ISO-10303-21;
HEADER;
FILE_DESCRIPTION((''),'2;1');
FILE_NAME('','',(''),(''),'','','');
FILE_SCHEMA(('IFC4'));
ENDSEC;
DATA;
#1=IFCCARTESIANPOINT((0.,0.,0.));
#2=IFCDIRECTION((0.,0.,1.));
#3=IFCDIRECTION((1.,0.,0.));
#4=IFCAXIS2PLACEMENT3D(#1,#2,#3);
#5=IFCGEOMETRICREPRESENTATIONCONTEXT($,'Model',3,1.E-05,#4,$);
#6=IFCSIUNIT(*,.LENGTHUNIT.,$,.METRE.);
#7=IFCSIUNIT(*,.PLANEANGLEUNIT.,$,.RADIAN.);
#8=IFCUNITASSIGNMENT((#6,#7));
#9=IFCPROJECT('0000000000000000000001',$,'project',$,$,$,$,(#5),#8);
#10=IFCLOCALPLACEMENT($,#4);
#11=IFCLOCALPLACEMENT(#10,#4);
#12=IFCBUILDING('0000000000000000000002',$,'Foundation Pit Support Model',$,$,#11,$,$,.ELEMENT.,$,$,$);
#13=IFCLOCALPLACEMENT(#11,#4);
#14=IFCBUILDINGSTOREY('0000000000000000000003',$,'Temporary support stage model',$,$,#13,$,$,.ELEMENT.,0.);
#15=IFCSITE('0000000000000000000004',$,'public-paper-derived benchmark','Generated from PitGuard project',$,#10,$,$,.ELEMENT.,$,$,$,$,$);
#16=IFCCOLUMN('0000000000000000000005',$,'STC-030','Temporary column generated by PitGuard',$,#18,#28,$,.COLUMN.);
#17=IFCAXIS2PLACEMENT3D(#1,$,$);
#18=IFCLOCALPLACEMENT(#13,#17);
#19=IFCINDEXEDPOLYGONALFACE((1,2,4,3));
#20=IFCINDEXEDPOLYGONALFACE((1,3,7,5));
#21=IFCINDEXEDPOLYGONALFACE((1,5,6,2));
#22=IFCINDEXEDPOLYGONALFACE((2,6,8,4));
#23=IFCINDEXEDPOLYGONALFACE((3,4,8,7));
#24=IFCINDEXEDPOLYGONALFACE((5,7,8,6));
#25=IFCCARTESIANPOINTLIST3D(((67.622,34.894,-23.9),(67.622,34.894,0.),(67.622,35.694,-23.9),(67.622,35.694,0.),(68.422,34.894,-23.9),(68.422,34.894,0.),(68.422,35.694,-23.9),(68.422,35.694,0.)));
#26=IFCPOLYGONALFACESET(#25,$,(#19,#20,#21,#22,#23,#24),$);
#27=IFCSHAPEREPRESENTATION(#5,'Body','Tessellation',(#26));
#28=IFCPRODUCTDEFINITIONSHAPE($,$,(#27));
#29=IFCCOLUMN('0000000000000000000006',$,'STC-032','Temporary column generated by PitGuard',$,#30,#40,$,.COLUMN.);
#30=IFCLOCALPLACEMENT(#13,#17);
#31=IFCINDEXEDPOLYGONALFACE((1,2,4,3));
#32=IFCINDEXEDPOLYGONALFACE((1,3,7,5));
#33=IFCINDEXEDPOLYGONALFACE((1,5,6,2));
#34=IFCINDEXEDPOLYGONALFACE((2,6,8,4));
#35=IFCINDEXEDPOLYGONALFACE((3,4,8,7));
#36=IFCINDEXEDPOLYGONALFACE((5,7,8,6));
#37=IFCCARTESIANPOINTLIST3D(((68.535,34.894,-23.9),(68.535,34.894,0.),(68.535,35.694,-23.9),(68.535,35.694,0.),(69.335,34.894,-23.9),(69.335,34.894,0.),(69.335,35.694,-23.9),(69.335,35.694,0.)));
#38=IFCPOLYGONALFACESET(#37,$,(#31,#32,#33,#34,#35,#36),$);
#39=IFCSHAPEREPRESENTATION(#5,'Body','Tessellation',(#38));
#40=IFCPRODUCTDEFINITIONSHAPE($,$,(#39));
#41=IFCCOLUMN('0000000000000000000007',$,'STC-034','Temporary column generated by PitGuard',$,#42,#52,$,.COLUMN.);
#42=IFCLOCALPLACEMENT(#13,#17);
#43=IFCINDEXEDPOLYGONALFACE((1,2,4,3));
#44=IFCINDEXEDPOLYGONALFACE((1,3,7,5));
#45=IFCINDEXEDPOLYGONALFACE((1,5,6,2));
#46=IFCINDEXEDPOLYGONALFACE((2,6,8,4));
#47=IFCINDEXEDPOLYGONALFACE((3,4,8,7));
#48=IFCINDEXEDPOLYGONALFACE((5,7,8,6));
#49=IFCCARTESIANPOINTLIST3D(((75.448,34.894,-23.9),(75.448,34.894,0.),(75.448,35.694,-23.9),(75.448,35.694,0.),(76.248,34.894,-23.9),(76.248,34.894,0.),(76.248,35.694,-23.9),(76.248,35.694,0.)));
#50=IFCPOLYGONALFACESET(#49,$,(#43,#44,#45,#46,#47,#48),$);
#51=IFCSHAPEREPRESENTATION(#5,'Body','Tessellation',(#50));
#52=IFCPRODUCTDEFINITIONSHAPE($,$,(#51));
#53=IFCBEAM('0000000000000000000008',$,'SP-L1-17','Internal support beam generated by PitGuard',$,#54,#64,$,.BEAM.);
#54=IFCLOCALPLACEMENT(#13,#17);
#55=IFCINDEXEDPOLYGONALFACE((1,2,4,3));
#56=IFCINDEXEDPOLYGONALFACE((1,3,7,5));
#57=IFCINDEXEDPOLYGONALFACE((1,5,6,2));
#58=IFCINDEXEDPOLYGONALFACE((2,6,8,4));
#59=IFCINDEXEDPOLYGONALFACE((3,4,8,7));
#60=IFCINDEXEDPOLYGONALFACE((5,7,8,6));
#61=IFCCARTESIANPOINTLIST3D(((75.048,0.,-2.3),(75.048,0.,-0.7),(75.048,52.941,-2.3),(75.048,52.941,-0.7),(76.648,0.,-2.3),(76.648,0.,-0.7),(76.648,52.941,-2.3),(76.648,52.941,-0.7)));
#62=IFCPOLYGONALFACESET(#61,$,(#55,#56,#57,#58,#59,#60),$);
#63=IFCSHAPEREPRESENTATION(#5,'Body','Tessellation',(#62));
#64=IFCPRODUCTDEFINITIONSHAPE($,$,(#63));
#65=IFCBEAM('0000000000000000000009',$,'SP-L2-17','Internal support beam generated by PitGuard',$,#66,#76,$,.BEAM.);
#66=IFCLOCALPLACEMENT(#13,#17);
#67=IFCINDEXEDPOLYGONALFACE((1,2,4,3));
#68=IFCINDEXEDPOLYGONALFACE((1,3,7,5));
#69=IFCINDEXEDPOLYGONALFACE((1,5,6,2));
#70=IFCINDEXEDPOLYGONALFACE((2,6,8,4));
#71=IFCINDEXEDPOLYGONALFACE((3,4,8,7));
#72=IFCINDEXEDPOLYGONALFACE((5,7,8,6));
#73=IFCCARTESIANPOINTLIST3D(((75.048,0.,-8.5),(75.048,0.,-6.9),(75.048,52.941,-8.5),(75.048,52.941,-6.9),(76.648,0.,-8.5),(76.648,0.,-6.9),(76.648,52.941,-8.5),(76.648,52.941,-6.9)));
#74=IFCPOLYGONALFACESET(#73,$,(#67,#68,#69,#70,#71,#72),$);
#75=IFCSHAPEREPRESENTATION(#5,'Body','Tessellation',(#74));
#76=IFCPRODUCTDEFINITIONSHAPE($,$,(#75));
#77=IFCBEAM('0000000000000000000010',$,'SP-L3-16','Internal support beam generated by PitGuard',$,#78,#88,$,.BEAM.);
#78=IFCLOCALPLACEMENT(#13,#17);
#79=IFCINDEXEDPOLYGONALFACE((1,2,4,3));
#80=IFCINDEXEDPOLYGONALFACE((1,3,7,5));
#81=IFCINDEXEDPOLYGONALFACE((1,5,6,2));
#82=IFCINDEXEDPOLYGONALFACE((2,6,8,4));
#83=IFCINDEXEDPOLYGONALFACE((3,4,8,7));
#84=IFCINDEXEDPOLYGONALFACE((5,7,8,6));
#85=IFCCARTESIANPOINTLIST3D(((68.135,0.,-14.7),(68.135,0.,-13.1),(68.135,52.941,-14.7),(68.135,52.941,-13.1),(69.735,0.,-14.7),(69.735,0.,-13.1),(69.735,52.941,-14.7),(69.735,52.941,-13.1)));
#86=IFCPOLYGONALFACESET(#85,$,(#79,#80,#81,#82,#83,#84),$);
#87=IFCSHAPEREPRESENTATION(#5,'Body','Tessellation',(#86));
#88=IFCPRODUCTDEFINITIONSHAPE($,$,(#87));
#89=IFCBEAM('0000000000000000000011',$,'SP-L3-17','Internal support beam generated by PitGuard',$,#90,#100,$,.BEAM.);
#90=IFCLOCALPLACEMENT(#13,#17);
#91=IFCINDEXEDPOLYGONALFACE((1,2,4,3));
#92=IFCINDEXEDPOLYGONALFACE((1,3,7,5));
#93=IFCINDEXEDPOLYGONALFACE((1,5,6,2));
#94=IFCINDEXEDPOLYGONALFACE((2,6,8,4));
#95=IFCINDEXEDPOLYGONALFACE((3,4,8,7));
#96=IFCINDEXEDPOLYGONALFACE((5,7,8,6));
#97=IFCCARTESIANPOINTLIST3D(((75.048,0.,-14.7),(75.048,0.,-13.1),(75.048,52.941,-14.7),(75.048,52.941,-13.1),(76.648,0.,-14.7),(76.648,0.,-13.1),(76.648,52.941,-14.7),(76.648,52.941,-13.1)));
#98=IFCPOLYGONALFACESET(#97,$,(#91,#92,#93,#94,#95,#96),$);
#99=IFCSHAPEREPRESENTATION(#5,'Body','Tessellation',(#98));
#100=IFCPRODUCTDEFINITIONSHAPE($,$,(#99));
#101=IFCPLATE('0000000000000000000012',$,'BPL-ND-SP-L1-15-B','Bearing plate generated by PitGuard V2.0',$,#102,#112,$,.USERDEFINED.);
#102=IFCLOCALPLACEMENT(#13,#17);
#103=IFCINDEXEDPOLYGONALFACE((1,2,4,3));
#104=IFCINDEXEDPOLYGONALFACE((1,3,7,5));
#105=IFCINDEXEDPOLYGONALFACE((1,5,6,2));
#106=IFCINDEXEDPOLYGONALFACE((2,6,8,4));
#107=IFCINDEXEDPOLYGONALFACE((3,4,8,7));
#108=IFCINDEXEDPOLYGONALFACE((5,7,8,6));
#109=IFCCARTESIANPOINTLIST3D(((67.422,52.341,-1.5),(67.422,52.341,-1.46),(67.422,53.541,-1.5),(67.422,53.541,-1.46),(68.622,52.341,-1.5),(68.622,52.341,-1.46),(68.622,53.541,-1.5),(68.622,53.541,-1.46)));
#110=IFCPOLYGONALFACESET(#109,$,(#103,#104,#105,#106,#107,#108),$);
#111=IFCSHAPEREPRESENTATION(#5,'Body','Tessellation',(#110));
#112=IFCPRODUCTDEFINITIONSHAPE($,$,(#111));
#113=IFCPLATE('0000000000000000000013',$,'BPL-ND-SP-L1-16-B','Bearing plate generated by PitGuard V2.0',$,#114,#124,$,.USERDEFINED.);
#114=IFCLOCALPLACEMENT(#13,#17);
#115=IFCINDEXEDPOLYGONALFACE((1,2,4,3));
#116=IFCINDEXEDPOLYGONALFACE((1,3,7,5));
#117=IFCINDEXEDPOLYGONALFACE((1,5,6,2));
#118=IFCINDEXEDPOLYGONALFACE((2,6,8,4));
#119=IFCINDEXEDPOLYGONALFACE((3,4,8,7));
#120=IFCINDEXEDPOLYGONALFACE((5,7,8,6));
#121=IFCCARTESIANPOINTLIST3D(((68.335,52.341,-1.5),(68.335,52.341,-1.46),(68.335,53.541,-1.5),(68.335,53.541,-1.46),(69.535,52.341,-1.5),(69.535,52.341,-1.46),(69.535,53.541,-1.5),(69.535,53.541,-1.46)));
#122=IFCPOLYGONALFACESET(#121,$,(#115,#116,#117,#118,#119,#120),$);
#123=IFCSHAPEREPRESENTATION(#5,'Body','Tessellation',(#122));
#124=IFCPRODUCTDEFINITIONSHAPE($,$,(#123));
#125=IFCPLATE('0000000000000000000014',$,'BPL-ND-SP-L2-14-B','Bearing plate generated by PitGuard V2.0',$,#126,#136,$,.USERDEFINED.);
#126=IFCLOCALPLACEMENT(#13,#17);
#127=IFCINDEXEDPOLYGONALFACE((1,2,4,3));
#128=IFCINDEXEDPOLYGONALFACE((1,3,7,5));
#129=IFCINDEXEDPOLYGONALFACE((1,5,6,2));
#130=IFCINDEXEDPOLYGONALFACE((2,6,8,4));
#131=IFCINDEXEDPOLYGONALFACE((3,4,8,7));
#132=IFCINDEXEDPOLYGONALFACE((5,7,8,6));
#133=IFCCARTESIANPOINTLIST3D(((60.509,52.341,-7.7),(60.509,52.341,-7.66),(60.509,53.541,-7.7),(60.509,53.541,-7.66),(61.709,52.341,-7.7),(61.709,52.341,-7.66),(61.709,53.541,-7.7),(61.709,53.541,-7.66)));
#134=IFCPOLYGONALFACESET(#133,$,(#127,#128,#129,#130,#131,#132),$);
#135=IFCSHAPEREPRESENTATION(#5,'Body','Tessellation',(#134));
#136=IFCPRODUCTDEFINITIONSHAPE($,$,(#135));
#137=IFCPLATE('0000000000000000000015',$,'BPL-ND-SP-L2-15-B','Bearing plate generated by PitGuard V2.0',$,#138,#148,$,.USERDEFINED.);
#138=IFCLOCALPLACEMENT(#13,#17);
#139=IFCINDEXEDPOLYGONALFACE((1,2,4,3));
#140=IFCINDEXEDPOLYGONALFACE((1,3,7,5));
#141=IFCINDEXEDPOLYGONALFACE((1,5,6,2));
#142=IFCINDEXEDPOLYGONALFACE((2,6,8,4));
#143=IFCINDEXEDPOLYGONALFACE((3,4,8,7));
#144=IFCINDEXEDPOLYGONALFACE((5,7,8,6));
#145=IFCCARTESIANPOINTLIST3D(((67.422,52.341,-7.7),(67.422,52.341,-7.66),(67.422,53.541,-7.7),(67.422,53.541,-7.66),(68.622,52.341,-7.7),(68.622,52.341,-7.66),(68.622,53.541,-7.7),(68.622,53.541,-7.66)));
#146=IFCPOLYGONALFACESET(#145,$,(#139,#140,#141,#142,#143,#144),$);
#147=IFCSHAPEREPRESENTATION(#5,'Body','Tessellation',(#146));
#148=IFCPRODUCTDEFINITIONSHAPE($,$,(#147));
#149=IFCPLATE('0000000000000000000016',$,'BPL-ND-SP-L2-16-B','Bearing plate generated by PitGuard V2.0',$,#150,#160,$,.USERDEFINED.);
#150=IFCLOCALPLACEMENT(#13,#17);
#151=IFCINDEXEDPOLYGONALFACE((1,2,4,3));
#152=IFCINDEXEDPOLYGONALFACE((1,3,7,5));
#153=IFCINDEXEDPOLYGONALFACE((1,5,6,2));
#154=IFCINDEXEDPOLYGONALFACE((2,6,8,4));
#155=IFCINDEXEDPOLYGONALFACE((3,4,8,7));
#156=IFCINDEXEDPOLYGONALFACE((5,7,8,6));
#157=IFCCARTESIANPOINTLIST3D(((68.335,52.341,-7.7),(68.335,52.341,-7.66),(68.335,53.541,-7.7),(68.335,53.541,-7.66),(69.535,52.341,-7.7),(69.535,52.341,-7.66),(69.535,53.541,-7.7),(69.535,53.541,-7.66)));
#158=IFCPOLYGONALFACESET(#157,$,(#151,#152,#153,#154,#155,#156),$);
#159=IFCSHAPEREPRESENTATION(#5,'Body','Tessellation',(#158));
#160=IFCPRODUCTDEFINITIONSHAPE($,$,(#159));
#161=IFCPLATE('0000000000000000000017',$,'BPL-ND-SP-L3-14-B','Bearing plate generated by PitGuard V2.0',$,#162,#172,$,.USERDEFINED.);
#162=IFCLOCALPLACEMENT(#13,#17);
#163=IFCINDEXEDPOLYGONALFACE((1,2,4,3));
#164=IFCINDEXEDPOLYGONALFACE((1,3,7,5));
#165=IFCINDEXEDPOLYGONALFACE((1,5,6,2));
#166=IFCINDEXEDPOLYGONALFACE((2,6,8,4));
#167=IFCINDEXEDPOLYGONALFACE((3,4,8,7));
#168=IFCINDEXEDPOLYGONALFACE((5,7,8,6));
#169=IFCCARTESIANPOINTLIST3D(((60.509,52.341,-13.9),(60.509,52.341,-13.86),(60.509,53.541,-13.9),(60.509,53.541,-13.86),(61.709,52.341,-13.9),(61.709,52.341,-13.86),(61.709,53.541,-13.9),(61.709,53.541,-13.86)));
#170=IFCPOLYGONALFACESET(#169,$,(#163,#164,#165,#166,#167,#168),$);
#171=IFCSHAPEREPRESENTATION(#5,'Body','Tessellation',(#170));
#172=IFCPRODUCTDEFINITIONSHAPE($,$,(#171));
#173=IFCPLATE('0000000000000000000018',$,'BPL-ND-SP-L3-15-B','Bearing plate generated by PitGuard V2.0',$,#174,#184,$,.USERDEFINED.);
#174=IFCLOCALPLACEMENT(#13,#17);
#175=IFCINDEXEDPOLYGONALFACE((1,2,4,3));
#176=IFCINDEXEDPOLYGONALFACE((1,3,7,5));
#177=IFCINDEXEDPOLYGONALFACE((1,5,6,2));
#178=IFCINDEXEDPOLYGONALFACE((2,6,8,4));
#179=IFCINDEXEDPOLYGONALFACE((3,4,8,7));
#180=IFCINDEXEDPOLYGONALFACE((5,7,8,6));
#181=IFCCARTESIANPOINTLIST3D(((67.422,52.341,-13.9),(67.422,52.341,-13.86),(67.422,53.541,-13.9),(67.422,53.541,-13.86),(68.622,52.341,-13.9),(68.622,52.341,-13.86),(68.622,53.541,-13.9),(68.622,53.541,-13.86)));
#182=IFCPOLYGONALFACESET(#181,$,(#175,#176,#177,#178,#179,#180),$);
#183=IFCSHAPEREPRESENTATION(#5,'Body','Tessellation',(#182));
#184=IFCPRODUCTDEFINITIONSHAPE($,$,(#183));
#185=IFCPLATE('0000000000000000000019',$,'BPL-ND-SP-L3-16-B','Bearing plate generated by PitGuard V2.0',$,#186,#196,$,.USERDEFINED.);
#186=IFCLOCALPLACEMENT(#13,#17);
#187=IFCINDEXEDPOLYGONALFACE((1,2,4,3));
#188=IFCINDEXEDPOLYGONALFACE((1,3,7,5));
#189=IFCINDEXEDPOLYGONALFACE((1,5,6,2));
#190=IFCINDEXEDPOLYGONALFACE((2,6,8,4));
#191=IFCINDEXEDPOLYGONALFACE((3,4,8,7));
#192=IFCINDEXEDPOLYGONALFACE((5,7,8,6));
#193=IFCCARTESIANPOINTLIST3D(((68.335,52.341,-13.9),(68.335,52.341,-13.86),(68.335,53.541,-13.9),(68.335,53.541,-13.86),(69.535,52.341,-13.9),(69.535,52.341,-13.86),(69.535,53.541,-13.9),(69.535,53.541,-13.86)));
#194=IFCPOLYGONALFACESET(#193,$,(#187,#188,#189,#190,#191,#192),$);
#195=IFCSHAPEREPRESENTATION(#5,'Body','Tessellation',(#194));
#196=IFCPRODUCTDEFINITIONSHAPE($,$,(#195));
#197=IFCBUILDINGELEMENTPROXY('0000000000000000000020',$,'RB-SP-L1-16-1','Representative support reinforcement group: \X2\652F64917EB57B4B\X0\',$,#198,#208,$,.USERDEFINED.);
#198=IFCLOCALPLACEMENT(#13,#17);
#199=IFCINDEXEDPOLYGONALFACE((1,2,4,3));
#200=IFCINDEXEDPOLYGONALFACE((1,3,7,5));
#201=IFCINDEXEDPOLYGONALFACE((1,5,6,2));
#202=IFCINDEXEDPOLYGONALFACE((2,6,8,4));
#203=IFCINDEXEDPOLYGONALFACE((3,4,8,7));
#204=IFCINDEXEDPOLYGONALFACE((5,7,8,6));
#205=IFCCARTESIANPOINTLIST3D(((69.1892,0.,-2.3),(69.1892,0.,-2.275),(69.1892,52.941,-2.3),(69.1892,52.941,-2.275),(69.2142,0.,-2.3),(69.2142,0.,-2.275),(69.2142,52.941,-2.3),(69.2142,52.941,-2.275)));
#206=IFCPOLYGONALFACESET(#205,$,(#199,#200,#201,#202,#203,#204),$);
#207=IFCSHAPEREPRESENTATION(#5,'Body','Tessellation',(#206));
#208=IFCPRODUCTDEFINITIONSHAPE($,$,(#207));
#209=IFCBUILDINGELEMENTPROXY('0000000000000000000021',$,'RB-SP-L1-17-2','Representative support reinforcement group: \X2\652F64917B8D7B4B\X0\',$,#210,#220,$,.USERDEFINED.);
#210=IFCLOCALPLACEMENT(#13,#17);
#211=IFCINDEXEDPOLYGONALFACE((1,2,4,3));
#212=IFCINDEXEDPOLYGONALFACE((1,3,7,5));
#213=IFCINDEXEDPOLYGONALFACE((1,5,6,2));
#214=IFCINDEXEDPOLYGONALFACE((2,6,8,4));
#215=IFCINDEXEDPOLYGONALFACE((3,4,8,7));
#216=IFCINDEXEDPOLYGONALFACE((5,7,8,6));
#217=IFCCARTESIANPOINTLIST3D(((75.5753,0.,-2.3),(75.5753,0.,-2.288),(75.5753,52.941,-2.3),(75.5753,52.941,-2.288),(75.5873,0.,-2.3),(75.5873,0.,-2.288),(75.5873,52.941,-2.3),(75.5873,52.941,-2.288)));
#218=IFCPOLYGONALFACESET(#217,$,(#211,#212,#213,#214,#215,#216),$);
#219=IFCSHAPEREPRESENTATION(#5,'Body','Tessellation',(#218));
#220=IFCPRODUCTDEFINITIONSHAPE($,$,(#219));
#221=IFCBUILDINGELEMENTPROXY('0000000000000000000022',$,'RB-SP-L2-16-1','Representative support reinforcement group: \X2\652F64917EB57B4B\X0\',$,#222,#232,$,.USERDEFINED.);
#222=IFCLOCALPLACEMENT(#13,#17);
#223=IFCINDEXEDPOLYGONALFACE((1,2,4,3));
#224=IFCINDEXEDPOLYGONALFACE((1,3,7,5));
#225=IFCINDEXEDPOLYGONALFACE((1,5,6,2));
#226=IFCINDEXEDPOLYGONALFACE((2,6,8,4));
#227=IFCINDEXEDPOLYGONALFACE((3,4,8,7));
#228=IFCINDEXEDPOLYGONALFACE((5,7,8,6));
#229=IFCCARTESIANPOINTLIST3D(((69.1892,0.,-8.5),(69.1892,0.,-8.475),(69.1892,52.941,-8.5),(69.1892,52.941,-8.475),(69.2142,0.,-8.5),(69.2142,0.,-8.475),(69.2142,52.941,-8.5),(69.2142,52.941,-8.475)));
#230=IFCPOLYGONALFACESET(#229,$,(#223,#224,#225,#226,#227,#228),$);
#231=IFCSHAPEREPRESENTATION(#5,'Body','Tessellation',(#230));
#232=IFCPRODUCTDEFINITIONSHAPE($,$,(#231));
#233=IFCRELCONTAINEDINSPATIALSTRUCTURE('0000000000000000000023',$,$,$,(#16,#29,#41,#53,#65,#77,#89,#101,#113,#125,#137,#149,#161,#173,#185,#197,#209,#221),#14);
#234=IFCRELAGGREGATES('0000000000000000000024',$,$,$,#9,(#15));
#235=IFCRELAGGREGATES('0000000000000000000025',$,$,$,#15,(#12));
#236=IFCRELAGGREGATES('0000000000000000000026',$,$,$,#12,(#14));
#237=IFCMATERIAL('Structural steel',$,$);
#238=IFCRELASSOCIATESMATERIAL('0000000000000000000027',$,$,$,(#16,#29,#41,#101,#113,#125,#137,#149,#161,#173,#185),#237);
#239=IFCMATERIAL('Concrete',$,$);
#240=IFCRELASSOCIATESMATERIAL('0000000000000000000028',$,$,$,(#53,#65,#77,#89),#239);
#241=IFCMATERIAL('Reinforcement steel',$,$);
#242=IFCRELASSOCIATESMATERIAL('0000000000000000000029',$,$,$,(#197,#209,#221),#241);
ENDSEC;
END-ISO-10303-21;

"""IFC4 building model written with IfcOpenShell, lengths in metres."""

from ifc_helpers import new_model, si_unit, frame, origin_with_axes, origin_2d, place, context, project, spatial, rectangle, extrude, material, element, save


model = new_model("IFC4")

# Units and contexts
model_context = context("Model", 3, precision=1e-05, world=origin_with_axes())
ifc_project = project(units=[si_unit("LENGTHUNIT", "METRE"), si_unit("PLANEANGLEUNIT", "RADIAN")], contexts=[model_context])

# Site, building, storey
site_placement = place(None, origin_with_axes())
site = spatial("IfcSite", under=ifc_project, at=site_placement, Name="public-paper-derived benchmark", Description="Generated from PitGuard project", CompositionType="ELEMENT")
building_placement = place(site_placement, origin_with_axes())
building = spatial("IfcBuilding", under=site, at=building_placement, Name="Foundation Pit Support Model", CompositionType="ELEMENT")
storey_placement = place(building_placement, origin_with_axes())
storey = spatial("IfcBuildingStorey", under=building, at=storey_placement, Name="Temporary support stage model", CompositionType="ELEMENT", Elevation=0.0)

# Columns
ifc_material_1 = material(Name="Structural steel")
for number, where, z_axis, x_axis, name in (
    (1, (68.022, 35.294, -23.9), (0.0, 0.0, 1.0), (1.0, 0.0, 0.0), "STC-030"),
    (2, (68.935, 35.294, -23.9), (0.0, 0.0, 1.0), (1.0, 0.0, 0.0), "STC-032"),
    (3, (75.848, 35.294, -23.9), (0.0, 0.0, 1.0), (1.0, 0.0, 0.0), "STC-034"),
):
    element("IfcColumn", number, at=place(storey_placement, frame(where, z_axis=z_axis, x_axis=x_axis)), inside=storey, material=ifc_material_1, Name=name, Description="Temporary column generated by PitGuard", PredefinedType="COLUMN", context=model_context, shape_type="SweptSolid", body=[
        extrude(rectangle(XDim=0.8, YDim=0.8, at=origin_2d()), origin_with_axes(), (0.0, 0.0, 1.0), 23.9),
    ])

# Beams
ifc_material_2 = material(Name="Concrete")
for number, where, z_axis, x_axis, name in (
    (4, (75.848, 26.4705, -2.3), (0.0, 0.0, 1.0), (0.0, 1.0, 0.0), "SP-L1-17"),
    (5, (75.848, 26.4705, -8.5), (0.0, 0.0, 1.0), (0.0, 1.0, 0.0), "SP-L2-17"),
    (6, (68.935, 26.4705, -14.7), (0.0, 0.0, 1.0), (0.0, 1.0, 0.0), "SP-L3-16"),
    (7, (75.848, 26.4705, -14.7), (0.0, 0.0, 1.0), (0.0, 1.0, 0.0), "SP-L3-17"),
):
    element("IfcBeam", number, at=place(storey_placement, frame(where, z_axis=z_axis, x_axis=x_axis)), inside=storey, material=ifc_material_2, Name=name, Description="Internal support beam generated by PitGuard", PredefinedType="BEAM", context=model_context, shape_type="SweptSolid", body=[
        extrude(rectangle(XDim=52.941, YDim=1.6, at=origin_2d()), origin_with_axes(), (0.0, 0.0, 1.0), 1.6),
    ])

# Plates
for number, where, z_axis, x_axis, name in (
    (8, (68.022, 52.941, -1.5), (0.0, 0.0, 1.0), (1.0, 0.0, 0.0), "BPL-ND-SP-L1-15-B"),
    (9, (68.935, 52.941, -1.5), (0.0, 0.0, 1.0), (1.0, 0.0, 0.0), "BPL-ND-SP-L1-16-B"),
    (10, (61.109, 52.941, -7.7), (0.0, 0.0, 1.0), (1.0, 0.0, 0.0), "BPL-ND-SP-L2-14-B"),
    (11, (68.022, 52.941, -7.7), (0.0, 0.0, 1.0), (1.0, 0.0, 0.0), "BPL-ND-SP-L2-15-B"),
    (12, (68.935, 52.941, -7.7), (0.0, 0.0, 1.0), (1.0, 0.0, 0.0), "BPL-ND-SP-L2-16-B"),
    (13, (61.109, 52.941, -13.9), (0.0, 0.0, 1.0), (1.0, 0.0, 0.0), "BPL-ND-SP-L3-14-B"),
    (14, (68.022, 52.941, -13.9), (0.0, 0.0, 1.0), (1.0, 0.0, 0.0), "BPL-ND-SP-L3-15-B"),
    (15, (68.935, 52.941, -13.9), (0.0, 0.0, 1.0), (1.0, 0.0, 0.0), "BPL-ND-SP-L3-16-B"),
):
    element("IfcPlate", number, at=place(storey_placement, frame(where, z_axis=z_axis, x_axis=x_axis)), inside=storey, material=ifc_material_1, Name=name, Description="Bearing plate generated by PitGuard V2.0", PredefinedType="USERDEFINED", context=model_context, shape_type="SweptSolid", body=[
        extrude(rectangle(XDim=1.2, YDim=1.2, at=origin_2d()), origin_with_axes(), (0.0, 0.0, 1.0), 0.04),
    ])

# Building element proxies
ifc_material_3 = material(Name="Reinforcement steel")
proxy_1_placement = place(storey_placement, frame((69.2017, 26.4705, -2.3), z_axis=(0.0, 0.0, 1.0), x_axis=(0.0, 1.0, 0.0)))
element("IfcBuildingElementProxy", 16, at=proxy_1_placement, inside=storey, material=ifc_material_3, Name="RB-SP-L1-16-1", Description="Representative support reinforcement group: 支撑纵筋", PredefinedType="USERDEFINED", context=model_context, shape_type="SweptSolid", body=[
    extrude(rectangle(XDim=52.941, YDim=0.025, at=origin_2d()), origin_with_axes(), (0.0, 0.0, 1.0), 0.025),
])
proxy_2_placement = place(storey_placement, frame((75.5813, 26.4705, -2.3), z_axis=(0.0, 0.0, 1.0), x_axis=(0.0, 1.0, 0.0)))
element("IfcBuildingElementProxy", 17, at=proxy_2_placement, inside=storey, material=ifc_material_3, Name="RB-SP-L1-17-2", Description="Representative support reinforcement group: 支撑箍筋", PredefinedType="USERDEFINED", context=model_context, shape_type="SweptSolid", body=[
    extrude(rectangle(XDim=52.941, YDim=0.012, at=origin_2d()), origin_with_axes(), (0.0, 0.0, 1.0), 0.012),
])
proxy_3_placement = place(storey_placement, frame((69.2017, 26.4705, -8.5), z_axis=(0.0, 0.0, 1.0), x_axis=(0.0, 1.0, 0.0)))
element("IfcBuildingElementProxy", 18, at=proxy_3_placement, inside=storey, material=ifc_material_3, Name="RB-SP-L2-16-1", Description="Representative support reinforcement group: 支撑纵筋", PredefinedType="USERDEFINED", context=model_context, shape_type="SweptSolid", body=[
    extrude(rectangle(XDim=52.941, YDim=0.025, at=origin_2d()), origin_with_axes(), (0.0, 0.0, 1.0), 0.025),
])

save(model, "model.ifc")
